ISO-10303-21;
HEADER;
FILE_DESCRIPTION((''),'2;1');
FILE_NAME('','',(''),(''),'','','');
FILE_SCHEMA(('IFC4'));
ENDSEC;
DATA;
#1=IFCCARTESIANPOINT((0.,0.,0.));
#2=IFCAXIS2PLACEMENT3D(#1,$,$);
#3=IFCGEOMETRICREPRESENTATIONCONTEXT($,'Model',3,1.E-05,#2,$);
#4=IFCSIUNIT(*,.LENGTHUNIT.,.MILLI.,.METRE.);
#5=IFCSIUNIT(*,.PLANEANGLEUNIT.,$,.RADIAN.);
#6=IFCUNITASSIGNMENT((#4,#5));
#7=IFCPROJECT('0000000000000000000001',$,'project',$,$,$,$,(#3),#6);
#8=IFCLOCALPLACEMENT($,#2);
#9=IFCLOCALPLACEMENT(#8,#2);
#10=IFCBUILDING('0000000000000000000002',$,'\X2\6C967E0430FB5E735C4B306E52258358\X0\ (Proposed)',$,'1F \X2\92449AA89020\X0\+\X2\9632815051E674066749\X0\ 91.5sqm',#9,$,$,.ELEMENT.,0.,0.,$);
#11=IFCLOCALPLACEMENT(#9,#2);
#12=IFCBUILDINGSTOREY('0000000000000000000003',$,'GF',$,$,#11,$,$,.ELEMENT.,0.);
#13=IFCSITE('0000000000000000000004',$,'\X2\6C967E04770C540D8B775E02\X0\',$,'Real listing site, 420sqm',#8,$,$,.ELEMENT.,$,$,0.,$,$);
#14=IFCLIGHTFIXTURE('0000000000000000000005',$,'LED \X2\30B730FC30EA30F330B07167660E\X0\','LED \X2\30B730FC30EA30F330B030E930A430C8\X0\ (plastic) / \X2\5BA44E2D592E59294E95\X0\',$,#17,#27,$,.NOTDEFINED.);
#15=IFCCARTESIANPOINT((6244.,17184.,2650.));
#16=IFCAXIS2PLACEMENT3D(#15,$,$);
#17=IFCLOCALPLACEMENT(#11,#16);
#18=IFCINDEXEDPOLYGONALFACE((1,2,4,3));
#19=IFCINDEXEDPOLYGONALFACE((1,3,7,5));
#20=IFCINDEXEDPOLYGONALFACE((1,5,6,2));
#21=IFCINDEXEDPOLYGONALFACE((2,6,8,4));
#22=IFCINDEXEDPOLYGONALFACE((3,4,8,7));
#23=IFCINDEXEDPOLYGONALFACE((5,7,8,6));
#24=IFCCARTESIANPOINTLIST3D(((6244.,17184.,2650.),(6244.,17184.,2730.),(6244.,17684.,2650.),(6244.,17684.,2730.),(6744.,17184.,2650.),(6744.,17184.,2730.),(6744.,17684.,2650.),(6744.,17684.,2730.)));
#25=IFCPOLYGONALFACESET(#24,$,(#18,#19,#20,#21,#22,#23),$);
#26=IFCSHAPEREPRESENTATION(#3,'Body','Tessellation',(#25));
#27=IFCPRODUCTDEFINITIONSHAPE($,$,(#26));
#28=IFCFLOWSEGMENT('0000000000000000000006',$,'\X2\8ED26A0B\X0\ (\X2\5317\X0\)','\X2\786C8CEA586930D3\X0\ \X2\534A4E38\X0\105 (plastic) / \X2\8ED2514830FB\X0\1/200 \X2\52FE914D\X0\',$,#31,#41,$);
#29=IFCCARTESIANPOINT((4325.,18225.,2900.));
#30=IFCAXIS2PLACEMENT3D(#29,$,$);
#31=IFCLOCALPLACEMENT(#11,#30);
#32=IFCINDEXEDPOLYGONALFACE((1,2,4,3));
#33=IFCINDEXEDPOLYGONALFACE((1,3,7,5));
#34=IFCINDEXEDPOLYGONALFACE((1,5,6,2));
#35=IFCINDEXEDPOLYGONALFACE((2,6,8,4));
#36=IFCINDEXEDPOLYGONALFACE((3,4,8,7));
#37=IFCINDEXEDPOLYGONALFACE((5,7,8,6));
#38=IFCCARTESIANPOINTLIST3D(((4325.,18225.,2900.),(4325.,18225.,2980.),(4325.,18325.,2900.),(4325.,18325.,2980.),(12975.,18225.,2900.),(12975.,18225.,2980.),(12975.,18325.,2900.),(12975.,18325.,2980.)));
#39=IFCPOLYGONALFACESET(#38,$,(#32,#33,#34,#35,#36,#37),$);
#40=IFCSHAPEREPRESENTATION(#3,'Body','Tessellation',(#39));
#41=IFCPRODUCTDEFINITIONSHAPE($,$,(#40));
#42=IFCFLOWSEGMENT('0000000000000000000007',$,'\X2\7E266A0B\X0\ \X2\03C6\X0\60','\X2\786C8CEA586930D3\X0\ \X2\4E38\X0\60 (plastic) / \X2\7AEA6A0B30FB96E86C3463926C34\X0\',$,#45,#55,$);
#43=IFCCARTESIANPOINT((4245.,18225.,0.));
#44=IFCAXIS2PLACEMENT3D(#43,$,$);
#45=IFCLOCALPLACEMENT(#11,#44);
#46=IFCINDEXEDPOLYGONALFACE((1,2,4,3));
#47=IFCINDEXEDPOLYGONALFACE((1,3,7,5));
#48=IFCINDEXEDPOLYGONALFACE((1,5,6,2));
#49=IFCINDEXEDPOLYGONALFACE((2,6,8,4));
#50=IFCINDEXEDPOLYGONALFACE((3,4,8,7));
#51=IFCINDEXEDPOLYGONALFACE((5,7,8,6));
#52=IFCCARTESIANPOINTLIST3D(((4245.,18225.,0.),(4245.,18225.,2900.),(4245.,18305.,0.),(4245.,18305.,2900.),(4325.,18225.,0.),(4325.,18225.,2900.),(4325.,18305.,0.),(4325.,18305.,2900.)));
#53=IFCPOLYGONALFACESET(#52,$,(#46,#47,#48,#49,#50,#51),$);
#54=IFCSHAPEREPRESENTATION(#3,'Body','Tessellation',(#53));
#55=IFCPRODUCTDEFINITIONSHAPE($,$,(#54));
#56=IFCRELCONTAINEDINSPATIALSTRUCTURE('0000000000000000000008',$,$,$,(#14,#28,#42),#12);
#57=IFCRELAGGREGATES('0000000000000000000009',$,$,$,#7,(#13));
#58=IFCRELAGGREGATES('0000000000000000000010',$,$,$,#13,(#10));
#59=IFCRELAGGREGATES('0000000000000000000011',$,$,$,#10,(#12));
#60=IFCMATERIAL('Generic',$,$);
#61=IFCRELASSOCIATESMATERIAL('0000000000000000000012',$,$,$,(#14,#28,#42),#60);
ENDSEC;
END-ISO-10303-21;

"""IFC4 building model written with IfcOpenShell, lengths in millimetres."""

from ifc_helpers import new_model, si_unit, frame, frame_2d, origin, place, context, project, spatial, rectangle, extrude, material, element, save


model = new_model("IFC4")

# Units and contexts
model_context = context("Model", 3, precision=1e-05, world=origin())
ifc_project = project(units=[si_unit("LENGTHUNIT", "METRE", prefix="MILLI"), si_unit("PLANEANGLEUNIT", "RADIAN")], contexts=[model_context])

# Site, building, storey
site_placement = place(None, origin())
site = spatial("IfcSite", under=ifc_project, at=site_placement, Name="沖縄県名護市", ObjectType="Real listing site, 420sqm", CompositionType="ELEMENT", RefElevation=0.0)
building_placement = place(site_placement, origin())
building = spatial("IfcBuilding", under=site, at=building_placement, Name="沖縄・平屋の別荘 (Proposed)", ObjectType="1F 鉄骨造+防腐処理杉 91.5sqm", CompositionType="ELEMENT", ElevationOfRefHeight=0.0, ElevationOfTerrain=0.0)
storey_placement = place(building_placement, origin())
storey = spatial("IfcBuildingStorey", under=building, at=storey_placement, Name="GF", CompositionType="ELEMENT", Elevation=0.0)

# Shared definitions
ifc_material_1 = material(Name="Generic")

# Light fixture
light_fixture_placement = place(storey_placement, frame((6244.0, 17184.0, 2650.0)))
element("IfcLightFixture", 1, at=light_fixture_placement, inside=storey, material=ifc_material_1, Name="LED シーリング照明", Description="LED シーリングライト (plastic) / 室中央天井", PredefinedType="NOTDEFINED", context=model_context, shape_type="SweptSolid", body=[
    extrude(rectangle(XDim=500.0, YDim=500.0, at=frame_2d((250.0, 250.0))), frame((6244.0, 17184.0, 2650.0)), (0.0, 0.0, 1.0), 80.0),
])

# Flow segments
flow_segment_1_placement = place(storey_placement, frame((4325.0, 18225.0, 2900.0)))
element("IfcFlowSegment", 2, at=flow_segment_1_placement, inside=storey, material=ifc_material_1, Name="軒樋 (北)", Description="硬質塩ビ 半丸105 (plastic) / 軒先・1/200 勾配", context=model_context, shape_type="SweptSolid", body=[
    extrude(rectangle(XDim=8650.0, YDim=100.0, at=frame_2d((4325.0, 50.0))), frame((4325.0, 18225.0, 2900.0)), (0.0, 0.0, 1.0), 80.0),
])
flow_segment_2_placement = place(storey_placement, frame((4245.0, 18225.0, 0.0)))
element("IfcFlowSegment", 3, at=flow_segment_2_placement, inside=storey, material=ifc_material_1, Name="縦樋 φ60", Description="硬質塩ビ 丸60 (plastic) / 竪樋・雨水排水", context=model_context, shape_type="SweptSolid", body=[
    extrude(rectangle(XDim=80.0, YDim=80.0, at=frame_2d((40.0, 40.0))), frame((4245.0, 18225.0, 0.0)), (0.0, 0.0, 1.0), 2900.0),
])

save(model, "model.ifc")
